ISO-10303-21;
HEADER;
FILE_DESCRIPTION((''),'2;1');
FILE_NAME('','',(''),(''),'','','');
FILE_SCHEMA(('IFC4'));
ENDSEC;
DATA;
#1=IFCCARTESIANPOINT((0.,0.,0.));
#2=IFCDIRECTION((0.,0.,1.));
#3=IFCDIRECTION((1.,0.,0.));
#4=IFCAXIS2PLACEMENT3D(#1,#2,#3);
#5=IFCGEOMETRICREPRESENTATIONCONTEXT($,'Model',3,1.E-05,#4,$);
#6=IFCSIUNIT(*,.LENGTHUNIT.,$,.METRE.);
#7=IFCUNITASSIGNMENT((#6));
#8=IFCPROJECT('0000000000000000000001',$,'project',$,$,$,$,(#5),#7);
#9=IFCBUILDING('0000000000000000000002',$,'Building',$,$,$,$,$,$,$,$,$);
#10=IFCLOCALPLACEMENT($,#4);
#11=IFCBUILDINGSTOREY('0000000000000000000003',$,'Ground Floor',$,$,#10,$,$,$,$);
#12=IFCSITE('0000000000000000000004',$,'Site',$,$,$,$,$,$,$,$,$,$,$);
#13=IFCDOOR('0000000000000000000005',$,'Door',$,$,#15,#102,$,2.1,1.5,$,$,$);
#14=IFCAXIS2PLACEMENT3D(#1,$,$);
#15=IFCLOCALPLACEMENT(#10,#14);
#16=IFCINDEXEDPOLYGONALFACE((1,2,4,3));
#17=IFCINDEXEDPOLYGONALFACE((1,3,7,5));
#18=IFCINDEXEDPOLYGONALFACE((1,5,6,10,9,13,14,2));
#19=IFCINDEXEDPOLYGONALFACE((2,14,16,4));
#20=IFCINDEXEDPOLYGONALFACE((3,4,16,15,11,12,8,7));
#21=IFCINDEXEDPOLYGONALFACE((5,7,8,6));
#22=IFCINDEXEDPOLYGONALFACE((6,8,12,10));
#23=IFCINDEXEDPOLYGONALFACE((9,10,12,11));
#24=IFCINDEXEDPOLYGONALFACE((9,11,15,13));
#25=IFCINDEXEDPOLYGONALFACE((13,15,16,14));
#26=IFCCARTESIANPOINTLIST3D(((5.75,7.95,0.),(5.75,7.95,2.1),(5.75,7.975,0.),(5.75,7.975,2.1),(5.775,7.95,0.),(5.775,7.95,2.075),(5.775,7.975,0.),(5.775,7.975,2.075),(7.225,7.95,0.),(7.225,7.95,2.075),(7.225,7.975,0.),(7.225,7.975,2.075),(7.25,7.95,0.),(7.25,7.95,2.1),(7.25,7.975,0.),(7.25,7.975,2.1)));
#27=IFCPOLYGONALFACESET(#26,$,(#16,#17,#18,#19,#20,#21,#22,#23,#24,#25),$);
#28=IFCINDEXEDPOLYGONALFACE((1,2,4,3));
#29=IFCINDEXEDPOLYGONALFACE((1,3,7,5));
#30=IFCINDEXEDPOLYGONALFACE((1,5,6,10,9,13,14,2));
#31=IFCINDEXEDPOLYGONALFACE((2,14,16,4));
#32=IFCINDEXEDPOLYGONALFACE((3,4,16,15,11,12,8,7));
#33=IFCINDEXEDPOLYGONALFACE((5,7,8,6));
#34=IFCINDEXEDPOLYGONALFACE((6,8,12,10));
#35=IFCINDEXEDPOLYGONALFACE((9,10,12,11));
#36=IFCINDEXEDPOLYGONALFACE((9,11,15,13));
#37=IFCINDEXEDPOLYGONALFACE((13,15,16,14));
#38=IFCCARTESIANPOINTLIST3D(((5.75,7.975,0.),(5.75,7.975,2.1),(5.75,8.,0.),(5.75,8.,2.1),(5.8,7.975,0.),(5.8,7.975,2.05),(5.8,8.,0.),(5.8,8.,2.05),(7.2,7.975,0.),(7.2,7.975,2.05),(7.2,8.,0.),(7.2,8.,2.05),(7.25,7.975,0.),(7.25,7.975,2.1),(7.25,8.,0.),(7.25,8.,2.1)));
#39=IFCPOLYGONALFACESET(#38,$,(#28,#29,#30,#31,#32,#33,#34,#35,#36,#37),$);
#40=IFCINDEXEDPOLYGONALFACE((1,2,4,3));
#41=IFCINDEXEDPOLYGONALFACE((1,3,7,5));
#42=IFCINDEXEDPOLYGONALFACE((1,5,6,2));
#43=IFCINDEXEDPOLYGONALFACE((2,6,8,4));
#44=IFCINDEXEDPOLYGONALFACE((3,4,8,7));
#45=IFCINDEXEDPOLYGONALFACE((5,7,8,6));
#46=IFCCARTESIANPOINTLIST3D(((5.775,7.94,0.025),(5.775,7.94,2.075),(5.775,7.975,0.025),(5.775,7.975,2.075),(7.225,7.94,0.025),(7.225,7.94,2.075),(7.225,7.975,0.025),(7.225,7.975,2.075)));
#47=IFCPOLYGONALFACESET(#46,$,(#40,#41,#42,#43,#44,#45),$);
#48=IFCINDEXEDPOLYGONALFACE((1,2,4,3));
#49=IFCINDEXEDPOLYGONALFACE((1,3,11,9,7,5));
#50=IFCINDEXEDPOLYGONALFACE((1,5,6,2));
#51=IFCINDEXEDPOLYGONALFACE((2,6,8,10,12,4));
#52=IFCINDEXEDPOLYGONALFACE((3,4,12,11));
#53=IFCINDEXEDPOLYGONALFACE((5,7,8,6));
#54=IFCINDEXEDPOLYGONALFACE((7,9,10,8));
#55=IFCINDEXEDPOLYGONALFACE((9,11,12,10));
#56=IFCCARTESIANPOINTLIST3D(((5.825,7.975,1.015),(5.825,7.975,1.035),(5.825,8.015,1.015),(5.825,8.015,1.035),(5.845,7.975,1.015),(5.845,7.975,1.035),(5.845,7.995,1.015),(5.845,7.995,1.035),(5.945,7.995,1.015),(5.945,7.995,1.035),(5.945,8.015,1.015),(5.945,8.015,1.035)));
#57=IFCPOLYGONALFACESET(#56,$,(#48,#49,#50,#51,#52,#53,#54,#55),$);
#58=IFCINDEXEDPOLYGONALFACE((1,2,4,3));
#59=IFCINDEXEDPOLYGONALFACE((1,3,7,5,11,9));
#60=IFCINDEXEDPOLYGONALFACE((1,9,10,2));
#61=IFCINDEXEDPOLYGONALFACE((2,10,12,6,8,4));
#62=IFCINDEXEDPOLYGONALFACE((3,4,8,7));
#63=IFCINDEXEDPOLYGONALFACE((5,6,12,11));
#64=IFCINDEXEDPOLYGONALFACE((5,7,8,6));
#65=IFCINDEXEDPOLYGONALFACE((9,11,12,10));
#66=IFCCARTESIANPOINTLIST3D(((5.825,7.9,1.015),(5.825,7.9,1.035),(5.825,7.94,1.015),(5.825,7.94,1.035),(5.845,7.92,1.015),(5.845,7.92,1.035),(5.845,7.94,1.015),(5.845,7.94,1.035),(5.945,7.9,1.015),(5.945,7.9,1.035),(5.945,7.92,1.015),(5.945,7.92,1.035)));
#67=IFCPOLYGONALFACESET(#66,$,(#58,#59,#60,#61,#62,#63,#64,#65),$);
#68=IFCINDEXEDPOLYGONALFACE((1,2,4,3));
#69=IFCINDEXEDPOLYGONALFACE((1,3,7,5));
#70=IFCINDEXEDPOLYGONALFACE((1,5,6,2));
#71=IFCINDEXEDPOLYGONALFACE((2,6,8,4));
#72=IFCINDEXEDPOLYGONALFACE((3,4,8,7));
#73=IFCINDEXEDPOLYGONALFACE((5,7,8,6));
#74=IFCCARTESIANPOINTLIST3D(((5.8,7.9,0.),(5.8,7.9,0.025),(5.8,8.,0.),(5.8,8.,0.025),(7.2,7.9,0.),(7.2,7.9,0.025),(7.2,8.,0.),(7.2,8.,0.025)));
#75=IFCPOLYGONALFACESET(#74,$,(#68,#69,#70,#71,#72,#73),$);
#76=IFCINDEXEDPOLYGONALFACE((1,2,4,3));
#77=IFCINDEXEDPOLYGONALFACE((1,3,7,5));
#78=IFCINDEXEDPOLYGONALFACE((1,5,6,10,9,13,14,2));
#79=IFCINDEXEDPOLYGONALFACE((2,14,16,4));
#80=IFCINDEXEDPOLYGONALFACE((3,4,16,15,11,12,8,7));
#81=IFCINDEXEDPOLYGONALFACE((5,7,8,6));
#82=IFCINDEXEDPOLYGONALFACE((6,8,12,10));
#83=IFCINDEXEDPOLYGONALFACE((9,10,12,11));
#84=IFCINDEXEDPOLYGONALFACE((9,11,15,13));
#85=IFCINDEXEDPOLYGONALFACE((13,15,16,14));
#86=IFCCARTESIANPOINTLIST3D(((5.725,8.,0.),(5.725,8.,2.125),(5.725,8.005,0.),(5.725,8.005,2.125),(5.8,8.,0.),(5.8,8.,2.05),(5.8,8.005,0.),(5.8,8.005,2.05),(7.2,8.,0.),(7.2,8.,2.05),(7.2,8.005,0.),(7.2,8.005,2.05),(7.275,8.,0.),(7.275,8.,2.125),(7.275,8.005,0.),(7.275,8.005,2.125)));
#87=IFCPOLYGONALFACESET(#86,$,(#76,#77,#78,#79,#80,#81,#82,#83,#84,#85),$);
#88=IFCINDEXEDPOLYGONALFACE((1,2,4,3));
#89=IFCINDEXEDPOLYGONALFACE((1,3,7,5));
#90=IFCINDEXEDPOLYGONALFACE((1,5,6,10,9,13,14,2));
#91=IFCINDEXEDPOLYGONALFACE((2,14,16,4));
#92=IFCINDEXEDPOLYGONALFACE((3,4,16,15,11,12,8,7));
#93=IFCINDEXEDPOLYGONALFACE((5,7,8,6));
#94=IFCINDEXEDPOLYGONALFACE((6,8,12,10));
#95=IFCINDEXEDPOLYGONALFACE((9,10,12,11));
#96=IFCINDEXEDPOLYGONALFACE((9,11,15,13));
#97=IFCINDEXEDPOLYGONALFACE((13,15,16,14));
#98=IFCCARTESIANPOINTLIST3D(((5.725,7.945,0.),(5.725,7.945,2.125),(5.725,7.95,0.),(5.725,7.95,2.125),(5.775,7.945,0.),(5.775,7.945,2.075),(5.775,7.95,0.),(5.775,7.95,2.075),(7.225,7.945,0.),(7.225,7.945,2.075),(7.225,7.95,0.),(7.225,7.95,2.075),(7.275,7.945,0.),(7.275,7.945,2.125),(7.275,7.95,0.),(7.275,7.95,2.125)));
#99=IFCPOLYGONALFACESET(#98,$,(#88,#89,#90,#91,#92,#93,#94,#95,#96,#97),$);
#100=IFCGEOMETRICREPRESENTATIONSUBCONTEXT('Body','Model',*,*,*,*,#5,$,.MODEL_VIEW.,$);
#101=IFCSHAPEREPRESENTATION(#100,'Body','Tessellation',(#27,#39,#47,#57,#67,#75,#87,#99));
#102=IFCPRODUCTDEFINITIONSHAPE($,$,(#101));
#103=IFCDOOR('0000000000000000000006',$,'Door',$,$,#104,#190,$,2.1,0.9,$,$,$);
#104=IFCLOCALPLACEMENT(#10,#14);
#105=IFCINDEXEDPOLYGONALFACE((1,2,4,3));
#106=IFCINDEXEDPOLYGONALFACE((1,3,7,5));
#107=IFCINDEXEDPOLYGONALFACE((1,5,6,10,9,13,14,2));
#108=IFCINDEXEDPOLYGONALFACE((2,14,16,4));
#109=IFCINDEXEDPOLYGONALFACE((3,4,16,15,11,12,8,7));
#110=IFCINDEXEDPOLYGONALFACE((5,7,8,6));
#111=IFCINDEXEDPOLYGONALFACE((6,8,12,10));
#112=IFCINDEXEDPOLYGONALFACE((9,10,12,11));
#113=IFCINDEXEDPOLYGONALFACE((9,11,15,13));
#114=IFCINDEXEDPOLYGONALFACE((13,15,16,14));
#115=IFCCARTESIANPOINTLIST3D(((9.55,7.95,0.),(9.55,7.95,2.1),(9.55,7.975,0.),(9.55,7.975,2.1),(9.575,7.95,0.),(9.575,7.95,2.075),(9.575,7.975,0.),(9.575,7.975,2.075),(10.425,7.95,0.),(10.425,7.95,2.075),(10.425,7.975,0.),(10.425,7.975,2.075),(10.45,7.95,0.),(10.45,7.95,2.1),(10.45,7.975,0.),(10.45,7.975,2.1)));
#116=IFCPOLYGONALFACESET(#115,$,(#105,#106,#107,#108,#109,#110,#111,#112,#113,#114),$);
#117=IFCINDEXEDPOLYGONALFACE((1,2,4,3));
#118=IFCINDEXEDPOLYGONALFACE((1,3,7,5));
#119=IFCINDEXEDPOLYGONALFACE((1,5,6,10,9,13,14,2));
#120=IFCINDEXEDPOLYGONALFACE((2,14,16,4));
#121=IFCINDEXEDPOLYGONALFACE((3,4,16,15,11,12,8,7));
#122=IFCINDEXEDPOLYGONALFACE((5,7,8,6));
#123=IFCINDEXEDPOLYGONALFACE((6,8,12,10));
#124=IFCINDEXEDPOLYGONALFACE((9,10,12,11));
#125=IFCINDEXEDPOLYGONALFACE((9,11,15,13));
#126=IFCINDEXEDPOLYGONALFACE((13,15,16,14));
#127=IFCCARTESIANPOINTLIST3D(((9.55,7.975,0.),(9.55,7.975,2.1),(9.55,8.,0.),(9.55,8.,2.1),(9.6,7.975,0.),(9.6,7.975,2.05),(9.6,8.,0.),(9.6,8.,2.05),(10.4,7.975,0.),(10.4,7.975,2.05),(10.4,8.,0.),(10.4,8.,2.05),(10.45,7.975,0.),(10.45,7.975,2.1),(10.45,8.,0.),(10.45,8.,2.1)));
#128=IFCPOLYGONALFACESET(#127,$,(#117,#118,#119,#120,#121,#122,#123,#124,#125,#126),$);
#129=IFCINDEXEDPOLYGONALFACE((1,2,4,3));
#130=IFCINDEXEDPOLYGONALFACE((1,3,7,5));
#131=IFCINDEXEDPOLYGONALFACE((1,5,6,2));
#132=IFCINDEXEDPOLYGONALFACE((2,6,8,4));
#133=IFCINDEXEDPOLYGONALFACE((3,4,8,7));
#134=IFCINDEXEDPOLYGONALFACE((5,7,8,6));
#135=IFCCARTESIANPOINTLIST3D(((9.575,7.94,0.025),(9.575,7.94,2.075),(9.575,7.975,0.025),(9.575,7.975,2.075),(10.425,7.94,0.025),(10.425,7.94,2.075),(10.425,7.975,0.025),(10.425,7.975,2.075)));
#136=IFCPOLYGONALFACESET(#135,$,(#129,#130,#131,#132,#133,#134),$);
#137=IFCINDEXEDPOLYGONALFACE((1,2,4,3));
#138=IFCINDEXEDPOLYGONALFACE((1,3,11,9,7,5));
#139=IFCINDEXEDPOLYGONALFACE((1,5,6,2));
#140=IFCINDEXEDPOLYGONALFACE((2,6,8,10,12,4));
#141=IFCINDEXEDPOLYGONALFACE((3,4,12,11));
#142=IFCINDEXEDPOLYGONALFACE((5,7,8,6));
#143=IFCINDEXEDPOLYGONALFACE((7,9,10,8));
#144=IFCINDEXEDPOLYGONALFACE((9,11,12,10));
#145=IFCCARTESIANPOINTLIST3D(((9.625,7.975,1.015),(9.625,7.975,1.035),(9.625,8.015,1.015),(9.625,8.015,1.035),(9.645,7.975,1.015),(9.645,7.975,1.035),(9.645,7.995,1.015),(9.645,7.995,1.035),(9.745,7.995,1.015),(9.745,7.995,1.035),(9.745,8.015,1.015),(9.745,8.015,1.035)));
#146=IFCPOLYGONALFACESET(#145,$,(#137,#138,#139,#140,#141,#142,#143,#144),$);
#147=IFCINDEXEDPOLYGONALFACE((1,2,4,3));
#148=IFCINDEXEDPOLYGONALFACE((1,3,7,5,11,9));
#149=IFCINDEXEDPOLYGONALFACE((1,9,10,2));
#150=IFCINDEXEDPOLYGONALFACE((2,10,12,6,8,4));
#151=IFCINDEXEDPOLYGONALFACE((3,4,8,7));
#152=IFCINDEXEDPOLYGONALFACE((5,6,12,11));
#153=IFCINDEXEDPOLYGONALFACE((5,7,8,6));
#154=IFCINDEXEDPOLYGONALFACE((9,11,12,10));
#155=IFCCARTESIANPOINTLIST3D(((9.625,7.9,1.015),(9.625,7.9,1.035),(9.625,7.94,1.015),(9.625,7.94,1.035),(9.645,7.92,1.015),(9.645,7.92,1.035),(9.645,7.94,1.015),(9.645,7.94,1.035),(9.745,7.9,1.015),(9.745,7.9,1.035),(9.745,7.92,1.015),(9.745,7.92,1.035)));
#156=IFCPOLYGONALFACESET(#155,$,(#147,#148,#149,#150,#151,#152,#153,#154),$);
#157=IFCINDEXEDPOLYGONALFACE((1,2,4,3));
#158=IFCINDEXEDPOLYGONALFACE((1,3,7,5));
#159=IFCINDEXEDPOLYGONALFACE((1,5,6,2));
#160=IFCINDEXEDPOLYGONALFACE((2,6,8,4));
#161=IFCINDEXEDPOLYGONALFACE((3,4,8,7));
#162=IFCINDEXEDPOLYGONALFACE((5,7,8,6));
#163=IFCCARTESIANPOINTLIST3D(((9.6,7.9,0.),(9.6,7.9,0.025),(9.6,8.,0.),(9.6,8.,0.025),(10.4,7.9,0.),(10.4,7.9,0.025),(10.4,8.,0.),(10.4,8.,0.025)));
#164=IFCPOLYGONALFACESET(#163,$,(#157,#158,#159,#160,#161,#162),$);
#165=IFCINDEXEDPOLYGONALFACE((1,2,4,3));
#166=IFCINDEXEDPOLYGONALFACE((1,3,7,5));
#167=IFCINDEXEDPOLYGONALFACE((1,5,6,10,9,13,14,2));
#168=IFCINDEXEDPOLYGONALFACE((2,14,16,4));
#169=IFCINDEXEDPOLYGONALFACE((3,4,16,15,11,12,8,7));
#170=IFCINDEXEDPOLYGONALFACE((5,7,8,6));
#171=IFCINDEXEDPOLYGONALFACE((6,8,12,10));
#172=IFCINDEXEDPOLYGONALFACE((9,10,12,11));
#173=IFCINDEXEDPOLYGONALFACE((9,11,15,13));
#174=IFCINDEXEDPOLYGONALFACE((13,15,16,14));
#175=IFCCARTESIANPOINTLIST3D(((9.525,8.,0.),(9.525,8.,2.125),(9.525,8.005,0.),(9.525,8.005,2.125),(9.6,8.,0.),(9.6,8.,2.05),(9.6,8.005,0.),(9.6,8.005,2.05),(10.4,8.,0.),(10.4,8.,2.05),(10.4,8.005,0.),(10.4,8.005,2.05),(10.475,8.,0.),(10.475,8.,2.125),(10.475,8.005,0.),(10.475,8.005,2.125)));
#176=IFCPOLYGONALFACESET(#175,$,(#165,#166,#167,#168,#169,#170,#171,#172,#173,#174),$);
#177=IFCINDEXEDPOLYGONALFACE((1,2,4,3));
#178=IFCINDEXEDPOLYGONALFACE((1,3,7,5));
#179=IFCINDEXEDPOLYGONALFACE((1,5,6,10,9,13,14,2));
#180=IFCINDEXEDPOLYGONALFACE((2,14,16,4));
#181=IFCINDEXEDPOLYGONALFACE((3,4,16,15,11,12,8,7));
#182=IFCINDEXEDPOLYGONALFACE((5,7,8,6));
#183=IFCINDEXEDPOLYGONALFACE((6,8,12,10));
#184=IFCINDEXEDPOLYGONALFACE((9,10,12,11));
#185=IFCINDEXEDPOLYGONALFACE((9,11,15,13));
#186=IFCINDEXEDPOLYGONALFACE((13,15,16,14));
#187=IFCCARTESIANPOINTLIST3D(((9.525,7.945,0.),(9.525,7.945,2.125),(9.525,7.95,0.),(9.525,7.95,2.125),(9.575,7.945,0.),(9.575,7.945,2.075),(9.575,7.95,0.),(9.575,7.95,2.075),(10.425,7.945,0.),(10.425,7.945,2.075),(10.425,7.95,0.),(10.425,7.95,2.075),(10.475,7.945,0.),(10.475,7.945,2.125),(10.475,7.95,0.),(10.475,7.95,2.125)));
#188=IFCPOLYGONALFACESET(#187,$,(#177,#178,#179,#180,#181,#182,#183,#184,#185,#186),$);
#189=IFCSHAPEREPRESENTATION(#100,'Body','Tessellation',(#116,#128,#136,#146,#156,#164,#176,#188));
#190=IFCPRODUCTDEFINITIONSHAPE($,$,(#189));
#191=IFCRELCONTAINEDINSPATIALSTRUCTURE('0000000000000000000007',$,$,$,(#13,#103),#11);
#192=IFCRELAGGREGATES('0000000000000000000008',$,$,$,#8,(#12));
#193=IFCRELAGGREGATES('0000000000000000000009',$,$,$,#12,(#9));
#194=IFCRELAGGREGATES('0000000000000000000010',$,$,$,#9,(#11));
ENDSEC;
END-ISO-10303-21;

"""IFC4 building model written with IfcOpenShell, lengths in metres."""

from ifc_helpers import new_model, si_unit, frame, origin_with_axes, place, context, subcontext, project, spatial, line, indexed_curve, outline, extrude, element, save


model = new_model("IFC4")

# Units and contexts
model_context = context("Model", 3, precision=1e-05, world=origin_with_axes())
body_context = subcontext(model_context, "Body", "Model", "MODEL_VIEW")
ifc_project = project(units=[si_unit("LENGTHUNIT", "METRE")], contexts=[model_context])

# Site, building, storey
site = spatial("IfcSite", under=ifc_project, Name="Site")
building = spatial("IfcBuilding", under=site, Name="Building")
storey_placement = place(None, origin_with_axes())
storey = spatial("IfcBuildingStorey", under=building, at=storey_placement, Name="Ground Floor")

# Doors
door_1_placement = place(storey_placement, frame((7.25, 8.0, 0.0), z_axis=(0.0, 0.0, 1.0), x_axis=(-1.0, 0.0, 0.0)))
element("IfcDoor", 1, at=door_1_placement, inside=storey, Name="Door", OverallHeight=2.1, OverallWidth=1.5, context=body_context, shape_type="SweptSolid", body=[
    extrude(outline(indexed_curve([(0.0, 0.0), (0.0, 2.1), (1.5, 2.1), (1.5, 0.0), (1.475, 0.0), (1.475, 2.075), (0.025, 2.075), (0.025, 0.0)], segments=[line(1, 2, 3, 4, 5, 6, 7, 8, 1)])), frame((0.0, 0.025, 0.0), z_axis=(0.0, -1.0, 0.0), x_axis=(1.0, 0.0, 0.0)), (0.0, 0.0, -1.0), 0.025),
    extrude(outline(indexed_curve([(0.0, 0.0), (0.0, 2.1), (1.5, 2.1), (1.5, 0.0), (1.45, 0.0), (1.45, 2.05), (0.05, 2.05), (0.05, 0.0)], segments=[line(1, 2, 3, 4, 5, 6, 7, 8, 1)])), frame((0.0, 0.0, 0.0), z_axis=(0.0, -1.0, 0.0), x_axis=(1.0, 0.0, 0.0)), (0.0, 0.0, -1.0), 0.025),
    extrude(outline(indexed_curve([(0.0, 0.0), (1.45, 0.0), (1.45, 0.035), (0.0, 0.035)], segments=[line(1, 2, 3, 4, 1)])), frame((0.025, 0.025, 0.025), z_axis=(0.0, 0.0, 1.0), x_axis=(1.0, 0.0, 0.0)), (0.0, 0.0, 1.0), 2.05),
    extrude(outline(indexed_curve([(0.0, 0.0), (0.0, -0.04), (-0.12, -0.04), (-0.12, -0.02), (-0.02, -0.02), (-0.02, 0.0)], segments=[line(1, 2, 3, 4, 5, 6, 1)])), frame((1.425, 0.025, 1.015), z_axis=(0.0, 0.0, 1.0), x_axis=(1.0, 0.0, 0.0)), (0.0, 0.0, 1.0), 0.02),
    extrude(outline(indexed_curve([(0.0, 0.0), (0.0, 0.04), (-0.12, 0.04), (-0.12, 0.02), (-0.02, 0.02), (-0.02, 0.0)], segments=[line(1, 2, 3, 4, 5, 6, 1)])), frame((1.425, 0.06, 1.015), z_axis=(0.0, 0.0, 1.0), x_axis=(1.0, 0.0, 0.0)), (0.0, 0.0, 1.0), 0.02),
    extrude(outline(indexed_curve([(0.0, 0.0), (1.4, 0.0), (1.4, 0.1), (0.0, 0.1)], segments=[line(1, 2, 3, 4, 1)])), frame((0.05, 0.0, 0.0), z_axis=(0.0, 0.0, 1.0), x_axis=(1.0, 0.0, 0.0)), (0.0, 0.0, 1.0), 0.025),
    extrude(outline(indexed_curve([(0.0, 0.0), (0.0, 2.125), (1.55, 2.125), (1.55, 0.0), (1.475, 0.0), (1.475, 2.05), (0.075, 2.05), (0.075, 0.0)], segments=[line(1, 2, 3, 4, 5, 6, 7, 8, 1)])), frame((-0.025, -0.005, 0.0), z_axis=(0.0, -1.0, 0.0), x_axis=(1.0, 0.0, 0.0)), (0.0, 0.0, -1.0), 0.005),
    extrude(outline(indexed_curve([(0.0, 0.0), (0.0, 2.125), (1.55, 2.125), (1.55, 0.0), (1.5, 0.0), (1.5, 2.075), (0.05, 2.075), (0.05, 0.0)], segments=[line(1, 2, 3, 4, 5, 6, 7, 8, 1)])), frame((-0.025, 0.05, 0.0), z_axis=(0.0, -1.0, 0.0), x_axis=(1.0, 0.0, 0.0)), (0.0, 0.0, -1.0), 0.005),
])
door_2_placement = place(storey_placement, frame((10.45, 8.0, 0.0), z_axis=(0.0, 0.0, 1.0), x_axis=(-1.0, 0.0, 0.0)))
element("IfcDoor", 2, at=door_2_placement, inside=storey, Name="Door", OverallHeight=2.1, OverallWidth=0.9, context=body_context, shape_type="SweptSolid", body=[
    extrude(outline(indexed_curve([(0.0, 0.0), (0.0, 2.1), (0.9, 2.1), (0.9, 0.0), (0.875, 0.0), (0.875, 2.075), (0.025, 2.075), (0.025, 0.0)], segments=[line(1, 2, 3, 4, 5, 6, 7, 8, 1)])), frame((0.0, 0.025, 0.0), z_axis=(0.0, -1.0, 0.0), x_axis=(1.0, 0.0, 0.0)), (0.0, 0.0, -1.0), 0.025),
    extrude(outline(indexed_curve([(0.0, 0.0), (0.0, 2.1), (0.9, 2.1), (0.9, 0.0), (0.85, 0.0), (0.85, 2.05), (0.05, 2.05), (0.05, 0.0)], segments=[line(1, 2, 3, 4, 5, 6, 7, 8, 1)])), frame((0.0, 0.0, 0.0), z_axis=(0.0, -1.0, 0.0), x_axis=(1.0, 0.0, 0.0)), (0.0, 0.0, -1.0), 0.025),
    extrude(outline(indexed_curve([(0.0, 0.0), (0.85, 0.0), (0.85, 0.035), (0.0, 0.035)], segments=[line(1, 2, 3, 4, 1)])), frame((0.025, 0.025, 0.025), z_axis=(0.0, 0.0, 1.0), x_axis=(1.0, 0.0, 0.0)), (0.0, 0.0, 1.0), 2.05),
    extrude(outline(indexed_curve([(0.0, 0.0), (0.0, -0.04), (-0.12, -0.04), (-0.12, -0.02), (-0.02, -0.02), (-0.02, 0.0)], segments=[line(1, 2, 3, 4, 5, 6, 1)])), frame((0.825, 0.025, 1.015), z_axis=(0.0, 0.0, 1.0), x_axis=(1.0, 0.0, 0.0)), (0.0, 0.0, 1.0), 0.02),
    extrude(outline(indexed_curve([(0.0, 0.0), (0.0, 0.04), (-0.12, 0.04), (-0.12, 0.02), (-0.02, 0.02), (-0.02, 0.0)], segments=[line(1, 2, 3, 4, 5, 6, 1)])), frame((0.825, 0.06, 1.015), z_axis=(0.0, 0.0, 1.0), x_axis=(1.0, 0.0, 0.0)), (0.0, 0.0, 1.0), 0.02),
    extrude(outline(indexed_curve([(0.0, 0.0), (0.8, 0.0), (0.8, 0.1), (0.0, 0.1)], segments=[line(1, 2, 3, 4, 1)])), frame((0.05, 0.0, 0.0), z_axis=(0.0, 0.0, 1.0), x_axis=(1.0, 0.0, 0.0)), (0.0, 0.0, 1.0), 0.025),
    extrude(outline(indexed_curve([(0.0, 0.0), (0.0, 2.125), (0.95, 2.125), (0.95, 0.0), (0.875, 0.0), (0.875, 2.05), (0.075, 2.05), (0.075, 0.0)], segments=[line(1, 2, 3, 4, 5, 6, 7, 8, 1)])), frame((-0.025, -0.005, 0.0), z_axis=(0.0, -1.0, 0.0), x_axis=(1.0, 0.0, 0.0)), (0.0, 0.0, -1.0), 0.005),
    extrude(outline(indexed_curve([(0.0, 0.0), (0.0, 2.125), (0.95, 2.125), (0.95, 0.0), (0.9, 0.0), (0.9, 2.075), (0.05, 2.075), (0.05, 0.0)], segments=[line(1, 2, 3, 4, 5, 6, 7, 8, 1)])), frame((-0.025, 0.05, 0.0), z_axis=(0.0, -1.0, 0.0), x_axis=(1.0, 0.0, 0.0)), (0.0, 0.0, -1.0), 0.005),
])

save(model, "model.ifc")
